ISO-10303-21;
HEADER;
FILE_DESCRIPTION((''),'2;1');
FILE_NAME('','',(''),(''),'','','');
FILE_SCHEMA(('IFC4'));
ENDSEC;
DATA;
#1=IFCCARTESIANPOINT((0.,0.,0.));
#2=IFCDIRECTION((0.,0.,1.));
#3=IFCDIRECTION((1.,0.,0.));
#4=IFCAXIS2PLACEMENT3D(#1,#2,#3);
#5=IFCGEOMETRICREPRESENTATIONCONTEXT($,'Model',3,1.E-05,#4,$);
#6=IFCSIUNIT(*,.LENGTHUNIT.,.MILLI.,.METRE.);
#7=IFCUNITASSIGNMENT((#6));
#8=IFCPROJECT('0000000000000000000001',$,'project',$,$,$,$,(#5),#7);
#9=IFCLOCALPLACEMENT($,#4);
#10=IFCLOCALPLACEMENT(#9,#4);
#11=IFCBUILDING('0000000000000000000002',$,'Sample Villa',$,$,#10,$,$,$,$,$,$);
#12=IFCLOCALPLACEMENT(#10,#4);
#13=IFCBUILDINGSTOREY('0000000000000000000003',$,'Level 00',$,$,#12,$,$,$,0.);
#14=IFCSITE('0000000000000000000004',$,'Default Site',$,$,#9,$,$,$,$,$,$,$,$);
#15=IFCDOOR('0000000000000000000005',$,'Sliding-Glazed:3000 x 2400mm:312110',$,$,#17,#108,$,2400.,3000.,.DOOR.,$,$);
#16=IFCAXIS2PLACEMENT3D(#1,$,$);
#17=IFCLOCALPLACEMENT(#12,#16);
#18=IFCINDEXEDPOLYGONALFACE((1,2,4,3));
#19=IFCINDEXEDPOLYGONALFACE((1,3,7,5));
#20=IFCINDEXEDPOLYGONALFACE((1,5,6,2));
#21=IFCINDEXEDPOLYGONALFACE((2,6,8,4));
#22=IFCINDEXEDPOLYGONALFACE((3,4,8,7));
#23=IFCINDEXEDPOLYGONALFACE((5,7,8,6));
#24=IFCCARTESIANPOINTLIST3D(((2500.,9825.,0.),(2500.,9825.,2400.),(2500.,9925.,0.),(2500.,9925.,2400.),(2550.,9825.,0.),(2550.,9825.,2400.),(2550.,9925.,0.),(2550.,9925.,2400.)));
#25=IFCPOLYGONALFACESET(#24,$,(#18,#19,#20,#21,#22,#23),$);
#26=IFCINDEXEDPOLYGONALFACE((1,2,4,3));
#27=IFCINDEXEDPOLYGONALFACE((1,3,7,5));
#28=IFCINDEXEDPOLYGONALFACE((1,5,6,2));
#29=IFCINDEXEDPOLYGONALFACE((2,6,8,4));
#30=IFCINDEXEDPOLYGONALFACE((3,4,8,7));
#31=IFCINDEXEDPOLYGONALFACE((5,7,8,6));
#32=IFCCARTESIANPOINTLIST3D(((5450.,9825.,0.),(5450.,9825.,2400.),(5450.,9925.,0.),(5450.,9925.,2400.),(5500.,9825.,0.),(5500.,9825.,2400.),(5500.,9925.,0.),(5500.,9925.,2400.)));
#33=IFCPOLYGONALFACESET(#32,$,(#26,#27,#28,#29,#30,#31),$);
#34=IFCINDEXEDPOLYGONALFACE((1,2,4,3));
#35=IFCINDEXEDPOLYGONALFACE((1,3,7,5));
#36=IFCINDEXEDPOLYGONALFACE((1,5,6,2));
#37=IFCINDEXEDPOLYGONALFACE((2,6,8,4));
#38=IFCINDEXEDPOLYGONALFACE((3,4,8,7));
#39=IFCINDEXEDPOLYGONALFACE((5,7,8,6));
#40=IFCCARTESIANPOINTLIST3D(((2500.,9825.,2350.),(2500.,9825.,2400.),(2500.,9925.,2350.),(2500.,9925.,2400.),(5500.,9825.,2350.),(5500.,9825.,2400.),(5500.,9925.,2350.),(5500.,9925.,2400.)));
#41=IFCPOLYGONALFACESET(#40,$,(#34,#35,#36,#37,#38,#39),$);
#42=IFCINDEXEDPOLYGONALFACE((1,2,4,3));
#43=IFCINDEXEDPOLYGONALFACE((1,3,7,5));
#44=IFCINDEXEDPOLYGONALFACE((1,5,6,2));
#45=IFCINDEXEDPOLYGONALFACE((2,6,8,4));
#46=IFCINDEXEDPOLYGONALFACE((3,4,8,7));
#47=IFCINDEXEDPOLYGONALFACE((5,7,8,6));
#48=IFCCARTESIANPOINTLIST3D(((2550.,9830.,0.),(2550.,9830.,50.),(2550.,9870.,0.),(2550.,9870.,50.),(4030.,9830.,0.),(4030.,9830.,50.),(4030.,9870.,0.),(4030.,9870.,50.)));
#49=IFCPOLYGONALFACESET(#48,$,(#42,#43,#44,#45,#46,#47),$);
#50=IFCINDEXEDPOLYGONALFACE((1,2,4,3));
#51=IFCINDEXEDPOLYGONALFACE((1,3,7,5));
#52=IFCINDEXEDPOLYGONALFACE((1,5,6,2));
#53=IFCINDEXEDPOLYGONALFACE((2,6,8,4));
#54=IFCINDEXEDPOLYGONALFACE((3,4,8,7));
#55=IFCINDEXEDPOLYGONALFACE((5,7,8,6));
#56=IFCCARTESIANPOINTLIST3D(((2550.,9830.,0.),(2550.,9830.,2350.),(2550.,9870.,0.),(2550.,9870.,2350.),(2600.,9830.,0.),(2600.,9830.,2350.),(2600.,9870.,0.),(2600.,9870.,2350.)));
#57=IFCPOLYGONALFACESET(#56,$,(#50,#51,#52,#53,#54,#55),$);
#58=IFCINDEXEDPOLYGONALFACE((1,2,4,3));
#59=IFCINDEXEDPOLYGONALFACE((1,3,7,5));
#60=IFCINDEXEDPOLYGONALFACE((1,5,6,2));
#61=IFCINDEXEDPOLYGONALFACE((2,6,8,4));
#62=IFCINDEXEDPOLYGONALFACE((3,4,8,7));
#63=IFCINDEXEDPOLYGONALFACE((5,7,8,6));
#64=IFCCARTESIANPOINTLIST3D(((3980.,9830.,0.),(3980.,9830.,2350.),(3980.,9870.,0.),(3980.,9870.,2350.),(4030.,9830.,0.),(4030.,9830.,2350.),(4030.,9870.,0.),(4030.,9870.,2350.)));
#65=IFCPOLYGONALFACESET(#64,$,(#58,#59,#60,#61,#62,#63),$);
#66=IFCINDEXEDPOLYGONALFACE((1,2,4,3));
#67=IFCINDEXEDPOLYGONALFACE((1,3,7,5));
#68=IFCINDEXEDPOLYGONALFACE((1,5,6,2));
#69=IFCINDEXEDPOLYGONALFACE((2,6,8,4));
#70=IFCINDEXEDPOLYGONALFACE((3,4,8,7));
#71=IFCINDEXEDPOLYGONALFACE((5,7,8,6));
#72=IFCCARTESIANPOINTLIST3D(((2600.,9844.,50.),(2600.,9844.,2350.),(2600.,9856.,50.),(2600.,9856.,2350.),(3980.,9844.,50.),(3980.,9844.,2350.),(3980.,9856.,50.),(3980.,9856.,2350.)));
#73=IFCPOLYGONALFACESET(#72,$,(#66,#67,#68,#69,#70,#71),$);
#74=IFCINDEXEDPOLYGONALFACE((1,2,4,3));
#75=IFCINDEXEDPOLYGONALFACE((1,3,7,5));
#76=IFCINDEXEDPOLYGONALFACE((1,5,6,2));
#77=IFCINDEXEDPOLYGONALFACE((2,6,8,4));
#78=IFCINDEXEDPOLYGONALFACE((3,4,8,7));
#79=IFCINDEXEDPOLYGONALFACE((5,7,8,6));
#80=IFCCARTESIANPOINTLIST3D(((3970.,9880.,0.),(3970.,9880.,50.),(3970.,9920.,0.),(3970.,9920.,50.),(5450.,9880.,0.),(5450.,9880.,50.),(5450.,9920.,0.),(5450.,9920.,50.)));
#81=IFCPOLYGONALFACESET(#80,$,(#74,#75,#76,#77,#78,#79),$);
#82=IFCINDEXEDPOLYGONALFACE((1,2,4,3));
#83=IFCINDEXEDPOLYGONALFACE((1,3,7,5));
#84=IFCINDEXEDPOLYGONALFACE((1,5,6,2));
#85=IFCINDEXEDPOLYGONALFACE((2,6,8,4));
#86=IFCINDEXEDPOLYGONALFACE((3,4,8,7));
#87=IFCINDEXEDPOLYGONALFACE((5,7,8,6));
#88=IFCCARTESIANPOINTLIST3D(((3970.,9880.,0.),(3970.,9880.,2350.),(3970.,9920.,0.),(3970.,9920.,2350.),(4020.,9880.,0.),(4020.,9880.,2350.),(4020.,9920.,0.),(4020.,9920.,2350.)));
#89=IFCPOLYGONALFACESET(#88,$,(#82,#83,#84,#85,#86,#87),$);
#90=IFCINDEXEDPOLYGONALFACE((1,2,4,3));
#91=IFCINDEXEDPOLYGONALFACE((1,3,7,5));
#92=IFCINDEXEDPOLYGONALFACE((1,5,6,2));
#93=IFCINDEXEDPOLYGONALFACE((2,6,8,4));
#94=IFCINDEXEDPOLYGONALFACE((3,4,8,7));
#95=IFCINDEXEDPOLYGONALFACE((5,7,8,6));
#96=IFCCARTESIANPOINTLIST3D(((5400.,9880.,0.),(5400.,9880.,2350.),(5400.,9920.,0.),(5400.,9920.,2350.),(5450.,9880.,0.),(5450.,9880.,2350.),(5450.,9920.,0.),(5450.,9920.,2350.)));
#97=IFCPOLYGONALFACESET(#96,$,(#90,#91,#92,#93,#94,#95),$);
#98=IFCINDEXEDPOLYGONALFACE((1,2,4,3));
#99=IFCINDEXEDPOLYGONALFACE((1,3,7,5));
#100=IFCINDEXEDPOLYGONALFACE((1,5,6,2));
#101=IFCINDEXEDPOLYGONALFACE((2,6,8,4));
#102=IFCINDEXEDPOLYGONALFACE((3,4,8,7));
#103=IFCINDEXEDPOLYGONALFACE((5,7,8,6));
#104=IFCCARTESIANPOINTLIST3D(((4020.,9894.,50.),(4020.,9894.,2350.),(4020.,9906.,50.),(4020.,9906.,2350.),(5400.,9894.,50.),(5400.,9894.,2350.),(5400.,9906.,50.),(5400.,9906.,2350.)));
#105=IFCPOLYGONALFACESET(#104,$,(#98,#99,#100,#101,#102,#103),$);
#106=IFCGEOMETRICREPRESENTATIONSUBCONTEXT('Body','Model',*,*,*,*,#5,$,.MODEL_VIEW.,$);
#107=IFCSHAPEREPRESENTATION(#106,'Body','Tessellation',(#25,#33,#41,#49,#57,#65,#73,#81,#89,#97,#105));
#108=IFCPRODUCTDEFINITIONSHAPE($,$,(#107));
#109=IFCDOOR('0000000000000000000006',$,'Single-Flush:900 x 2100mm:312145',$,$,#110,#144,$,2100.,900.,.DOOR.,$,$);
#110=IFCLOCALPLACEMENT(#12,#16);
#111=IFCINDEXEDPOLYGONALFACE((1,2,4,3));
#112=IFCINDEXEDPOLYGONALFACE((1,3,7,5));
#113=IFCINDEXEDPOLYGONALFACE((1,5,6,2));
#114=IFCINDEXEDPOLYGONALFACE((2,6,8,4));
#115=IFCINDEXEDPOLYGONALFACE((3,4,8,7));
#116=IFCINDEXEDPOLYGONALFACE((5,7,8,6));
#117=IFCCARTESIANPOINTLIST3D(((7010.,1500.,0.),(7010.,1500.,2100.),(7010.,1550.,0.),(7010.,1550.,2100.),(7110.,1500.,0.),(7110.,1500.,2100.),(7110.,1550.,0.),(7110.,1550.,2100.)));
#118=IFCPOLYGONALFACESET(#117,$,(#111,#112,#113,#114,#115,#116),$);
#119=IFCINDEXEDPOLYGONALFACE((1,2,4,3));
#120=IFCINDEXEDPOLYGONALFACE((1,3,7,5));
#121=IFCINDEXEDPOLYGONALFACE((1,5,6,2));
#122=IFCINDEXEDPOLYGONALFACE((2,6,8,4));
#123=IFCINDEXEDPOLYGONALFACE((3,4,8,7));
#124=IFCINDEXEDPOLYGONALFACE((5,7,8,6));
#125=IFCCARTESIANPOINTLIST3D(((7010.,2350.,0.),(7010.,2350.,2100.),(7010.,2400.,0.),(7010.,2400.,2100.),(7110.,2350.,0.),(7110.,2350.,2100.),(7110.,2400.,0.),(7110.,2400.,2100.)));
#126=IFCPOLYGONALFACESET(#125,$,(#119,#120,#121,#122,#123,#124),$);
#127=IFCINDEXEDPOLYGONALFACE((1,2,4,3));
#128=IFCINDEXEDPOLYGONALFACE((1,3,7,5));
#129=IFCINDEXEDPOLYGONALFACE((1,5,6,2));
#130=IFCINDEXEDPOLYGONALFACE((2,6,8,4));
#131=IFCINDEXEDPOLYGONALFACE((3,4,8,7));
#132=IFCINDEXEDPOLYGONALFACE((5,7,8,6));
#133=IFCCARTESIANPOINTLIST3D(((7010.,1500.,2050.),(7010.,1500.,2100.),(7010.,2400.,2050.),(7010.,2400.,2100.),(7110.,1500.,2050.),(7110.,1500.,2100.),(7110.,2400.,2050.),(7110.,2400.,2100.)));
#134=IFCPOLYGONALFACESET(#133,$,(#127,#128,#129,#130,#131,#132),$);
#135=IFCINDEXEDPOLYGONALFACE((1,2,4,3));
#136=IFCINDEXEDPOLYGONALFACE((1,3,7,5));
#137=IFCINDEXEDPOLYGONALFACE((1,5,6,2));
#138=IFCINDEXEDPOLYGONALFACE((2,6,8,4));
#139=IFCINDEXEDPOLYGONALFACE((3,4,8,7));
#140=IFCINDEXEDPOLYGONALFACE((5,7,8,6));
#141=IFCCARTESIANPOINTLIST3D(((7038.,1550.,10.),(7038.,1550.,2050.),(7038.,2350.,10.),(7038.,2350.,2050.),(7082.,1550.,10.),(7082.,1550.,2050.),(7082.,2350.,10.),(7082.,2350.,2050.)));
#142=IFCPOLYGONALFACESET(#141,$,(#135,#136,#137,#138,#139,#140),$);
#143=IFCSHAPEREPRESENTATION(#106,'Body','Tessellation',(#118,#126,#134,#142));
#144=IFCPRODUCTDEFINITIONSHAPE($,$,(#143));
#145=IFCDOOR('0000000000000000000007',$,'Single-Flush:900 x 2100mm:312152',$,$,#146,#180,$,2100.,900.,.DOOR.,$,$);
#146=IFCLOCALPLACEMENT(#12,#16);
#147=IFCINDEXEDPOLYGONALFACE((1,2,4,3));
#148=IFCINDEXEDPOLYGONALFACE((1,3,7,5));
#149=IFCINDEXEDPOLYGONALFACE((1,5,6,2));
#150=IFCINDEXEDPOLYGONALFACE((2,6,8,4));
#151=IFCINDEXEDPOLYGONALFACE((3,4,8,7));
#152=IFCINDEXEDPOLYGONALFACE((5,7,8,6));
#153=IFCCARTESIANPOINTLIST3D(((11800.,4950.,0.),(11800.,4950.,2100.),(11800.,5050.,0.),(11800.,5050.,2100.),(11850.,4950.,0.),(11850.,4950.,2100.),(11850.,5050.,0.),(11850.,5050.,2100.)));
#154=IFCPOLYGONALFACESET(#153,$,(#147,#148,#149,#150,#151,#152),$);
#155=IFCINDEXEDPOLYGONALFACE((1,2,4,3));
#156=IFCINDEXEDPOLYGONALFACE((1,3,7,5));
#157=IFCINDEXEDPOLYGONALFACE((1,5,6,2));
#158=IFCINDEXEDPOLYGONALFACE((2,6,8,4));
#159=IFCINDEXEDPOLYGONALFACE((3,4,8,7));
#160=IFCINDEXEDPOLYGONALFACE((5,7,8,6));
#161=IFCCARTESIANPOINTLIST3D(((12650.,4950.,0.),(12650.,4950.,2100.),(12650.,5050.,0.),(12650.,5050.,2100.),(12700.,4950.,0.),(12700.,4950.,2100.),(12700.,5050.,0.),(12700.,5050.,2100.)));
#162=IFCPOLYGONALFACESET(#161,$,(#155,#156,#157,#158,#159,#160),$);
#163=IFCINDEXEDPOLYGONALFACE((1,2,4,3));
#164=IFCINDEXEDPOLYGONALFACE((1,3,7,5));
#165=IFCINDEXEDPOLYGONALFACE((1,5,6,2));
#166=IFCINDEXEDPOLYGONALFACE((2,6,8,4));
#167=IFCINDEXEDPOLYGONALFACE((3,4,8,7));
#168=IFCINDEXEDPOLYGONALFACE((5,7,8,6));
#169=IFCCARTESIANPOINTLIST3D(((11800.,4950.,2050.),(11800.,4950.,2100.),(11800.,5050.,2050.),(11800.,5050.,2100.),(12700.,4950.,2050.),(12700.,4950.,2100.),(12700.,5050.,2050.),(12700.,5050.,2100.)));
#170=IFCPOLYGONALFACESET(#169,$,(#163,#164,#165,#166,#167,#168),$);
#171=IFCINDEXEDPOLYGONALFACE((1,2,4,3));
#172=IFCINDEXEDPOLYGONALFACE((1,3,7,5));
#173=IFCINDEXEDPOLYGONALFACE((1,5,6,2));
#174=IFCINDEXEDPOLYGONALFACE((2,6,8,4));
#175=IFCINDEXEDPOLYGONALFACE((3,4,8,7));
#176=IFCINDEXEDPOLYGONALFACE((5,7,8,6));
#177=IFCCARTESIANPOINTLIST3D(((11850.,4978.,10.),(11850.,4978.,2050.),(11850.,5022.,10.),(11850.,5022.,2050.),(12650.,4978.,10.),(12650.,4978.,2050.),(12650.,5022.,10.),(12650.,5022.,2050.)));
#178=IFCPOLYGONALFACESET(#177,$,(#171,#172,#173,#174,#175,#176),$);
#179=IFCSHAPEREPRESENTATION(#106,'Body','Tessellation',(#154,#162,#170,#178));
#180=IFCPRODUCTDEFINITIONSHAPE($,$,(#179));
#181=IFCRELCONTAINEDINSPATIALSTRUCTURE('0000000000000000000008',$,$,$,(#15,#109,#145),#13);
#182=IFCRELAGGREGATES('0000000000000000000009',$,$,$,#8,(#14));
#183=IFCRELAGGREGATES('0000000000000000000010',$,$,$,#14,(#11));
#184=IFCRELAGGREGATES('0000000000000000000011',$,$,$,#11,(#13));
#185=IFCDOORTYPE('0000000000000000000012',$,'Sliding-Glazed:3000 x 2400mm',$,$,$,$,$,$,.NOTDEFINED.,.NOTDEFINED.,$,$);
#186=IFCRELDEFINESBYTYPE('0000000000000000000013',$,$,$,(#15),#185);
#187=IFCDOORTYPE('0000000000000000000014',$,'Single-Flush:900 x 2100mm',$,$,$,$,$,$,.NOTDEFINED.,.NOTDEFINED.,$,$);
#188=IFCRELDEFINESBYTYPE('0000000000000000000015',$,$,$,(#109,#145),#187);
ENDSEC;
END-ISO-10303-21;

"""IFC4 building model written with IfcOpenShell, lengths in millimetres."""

from ifc_helpers import new_model, si_unit, frame, frame_2d, origin_with_axes, place, context, subcontext, project, spatial, rectangle, extrude, type_object, element, save


model = new_model("IFC4")

# Units and contexts
model_context = context("Model", 3, precision=1e-05, world=origin_with_axes())
body_context = subcontext(model_context, "Body", "Model", "MODEL_VIEW")
ifc_project = project(units=[si_unit("LENGTHUNIT", "METRE", prefix="MILLI")], contexts=[model_context])

# Site, building, storey
site_placement = place(None, origin_with_axes())
site = spatial("IfcSite", under=ifc_project, at=site_placement, Name="Default Site")
building_placement = place(site_placement, origin_with_axes())
building = spatial("IfcBuilding", under=site, at=building_placement, Name="Sample Villa")
storey_placement = place(building_placement, origin_with_axes())
storey = spatial("IfcBuildingStorey", under=building, at=storey_placement, Name="Level 00", Elevation=0.0)

# Doors
door_type_1 = type_object("IfcDoorType", Name="Sliding-Glazed:3000 x 2400mm", OperationType="NOTDEFINED", PredefinedType="NOTDEFINED")
door_1_placement = place(storey_placement, origin_with_axes())
element("IfcDoor", 1, at=door_1_placement, inside=storey, type_object=door_type_1, Name="Sliding-Glazed:3000 x 2400mm:312110", OverallHeight=2400.0, OverallWidth=3000.0, PredefinedType="DOOR", context=body_context, shape_type="SweptSolid", body=[
    extrude(rectangle(XDim=50.0, YDim=100.0, at=frame_2d((25.0, 50.0))), frame((2500.0, 9825.0, 0.0)), (0.0, 0.0, 1.0), 2400.0),
    extrude(rectangle(XDim=50.0, YDim=100.0, at=frame_2d((25.0, 50.0))), frame((5450.0, 9825.0, 0.0)), (0.0, 0.0, 1.0), 2400.0),
    extrude(rectangle(XDim=3000.0, YDim=100.0, at=frame_2d((1500.0, 50.0))), frame((2500.0, 9825.0, 2350.0)), (0.0, 0.0, 1.0), 50.0),
    extrude(rectangle(XDim=1480.0, YDim=40.0, at=frame_2d((740.0, 20.0))), frame((2550.0, 9830.0, 0.0)), (0.0, 0.0, 1.0), 50.0),
    extrude(rectangle(XDim=50.0, YDim=40.0, at=frame_2d((25.0, 20.0))), frame((2550.0, 9830.0, 0.0)), (0.0, 0.0, 1.0), 2350.0),
    extrude(rectangle(XDim=50.0, YDim=40.0, at=frame_2d((25.0, 20.0))), frame((3980.0, 9830.0, 0.0)), (0.0, 0.0, 1.0), 2350.0),
    extrude(rectangle(XDim=1380.0, YDim=12.0, at=frame_2d((690.0, 6.0))), frame((2600.0, 9844.0, 50.0)), (0.0, 0.0, 1.0), 2300.0),
    extrude(rectangle(XDim=1480.0, YDim=40.0, at=frame_2d((740.0, 20.0))), frame((3970.0, 9880.0, 0.0)), (0.0, 0.0, 1.0), 50.0),
    extrude(rectangle(XDim=50.0, YDim=40.0, at=frame_2d((25.0, 20.0))), frame((3970.0, 9880.0, 0.0)), (0.0, 0.0, 1.0), 2350.0),
    extrude(rectangle(XDim=50.0, YDim=40.0, at=frame_2d((25.0, 20.0))), frame((5400.0, 9880.0, 0.0)), (0.0, 0.0, 1.0), 2350.0),
    extrude(rectangle(XDim=1380.0, YDim=12.0, at=frame_2d((690.0, 6.0))), frame((4020.0, 9894.0, 50.0)), (0.0, 0.0, 1.0), 2300.0),
])
door_type_2 = type_object("IfcDoorType", Name="Single-Flush:900 x 2100mm", OperationType="NOTDEFINED", PredefinedType="NOTDEFINED")
door_2_placement = place(storey_placement, origin_with_axes())
element("IfcDoor", 2, at=door_2_placement, inside=storey, type_object=door_type_2, Name="Single-Flush:900 x 2100mm:312145", OverallHeight=2100.0, OverallWidth=900.0, PredefinedType="DOOR", context=body_context, shape_type="SweptSolid", body=[
    extrude(rectangle(XDim=100.0, YDim=50.0, at=frame_2d((50.0, 25.0))), frame((7010.0, 1500.0, 0.0)), (0.0, 0.0, 1.0), 2100.0),
    extrude(rectangle(XDim=100.0, YDim=50.0, at=frame_2d((50.0, 25.0))), frame((7010.0, 2350.0, 0.0)), (0.0, 0.0, 1.0), 2100.0),
    extrude(rectangle(XDim=100.0, YDim=900.0, at=frame_2d((50.0, 450.0))), frame((7010.0, 1500.0, 2050.0)), (0.0, 0.0, 1.0), 50.0),
    extrude(rectangle(XDim=44.0, YDim=800.0, at=frame_2d((22.0, 400.0))), frame((7038.0, 1550.0, 10.0)), (0.0, 0.0, 1.0), 2040.0),
])
door_3_placement = place(storey_placement, origin_with_axes())
element("IfcDoor", 3, at=door_3_placement, inside=storey, type_object=door_type_2, Name="Single-Flush:900 x 2100mm:312152", OverallHeight=2100.0, OverallWidth=900.0, PredefinedType="DOOR", context=body_context, shape_type="SweptSolid", body=[
    extrude(rectangle(XDim=50.0, YDim=100.0, at=frame_2d((25.0, 50.0))), frame((11800.0, 4950.0, 0.0)), (0.0, 0.0, 1.0), 2100.0),
    extrude(rectangle(XDim=50.0, YDim=100.0, at=frame_2d((25.0, 50.0))), frame((12650.0, 4950.0, 0.0)), (0.0, 0.0, 1.0), 2100.0),
    extrude(rectangle(XDim=900.0, YDim=100.0, at=frame_2d((450.0, 50.0))), frame((11800.0, 4950.0, 2050.0)), (0.0, 0.0, 1.0), 50.0),
    extrude(rectangle(XDim=800.0, YDim=44.0, at=frame_2d((400.0, 22.0))), frame((11850.0, 4978.0, 10.0)), (0.0, 0.0, 1.0), 2040.0),
])

save(model, "model.ifc")
